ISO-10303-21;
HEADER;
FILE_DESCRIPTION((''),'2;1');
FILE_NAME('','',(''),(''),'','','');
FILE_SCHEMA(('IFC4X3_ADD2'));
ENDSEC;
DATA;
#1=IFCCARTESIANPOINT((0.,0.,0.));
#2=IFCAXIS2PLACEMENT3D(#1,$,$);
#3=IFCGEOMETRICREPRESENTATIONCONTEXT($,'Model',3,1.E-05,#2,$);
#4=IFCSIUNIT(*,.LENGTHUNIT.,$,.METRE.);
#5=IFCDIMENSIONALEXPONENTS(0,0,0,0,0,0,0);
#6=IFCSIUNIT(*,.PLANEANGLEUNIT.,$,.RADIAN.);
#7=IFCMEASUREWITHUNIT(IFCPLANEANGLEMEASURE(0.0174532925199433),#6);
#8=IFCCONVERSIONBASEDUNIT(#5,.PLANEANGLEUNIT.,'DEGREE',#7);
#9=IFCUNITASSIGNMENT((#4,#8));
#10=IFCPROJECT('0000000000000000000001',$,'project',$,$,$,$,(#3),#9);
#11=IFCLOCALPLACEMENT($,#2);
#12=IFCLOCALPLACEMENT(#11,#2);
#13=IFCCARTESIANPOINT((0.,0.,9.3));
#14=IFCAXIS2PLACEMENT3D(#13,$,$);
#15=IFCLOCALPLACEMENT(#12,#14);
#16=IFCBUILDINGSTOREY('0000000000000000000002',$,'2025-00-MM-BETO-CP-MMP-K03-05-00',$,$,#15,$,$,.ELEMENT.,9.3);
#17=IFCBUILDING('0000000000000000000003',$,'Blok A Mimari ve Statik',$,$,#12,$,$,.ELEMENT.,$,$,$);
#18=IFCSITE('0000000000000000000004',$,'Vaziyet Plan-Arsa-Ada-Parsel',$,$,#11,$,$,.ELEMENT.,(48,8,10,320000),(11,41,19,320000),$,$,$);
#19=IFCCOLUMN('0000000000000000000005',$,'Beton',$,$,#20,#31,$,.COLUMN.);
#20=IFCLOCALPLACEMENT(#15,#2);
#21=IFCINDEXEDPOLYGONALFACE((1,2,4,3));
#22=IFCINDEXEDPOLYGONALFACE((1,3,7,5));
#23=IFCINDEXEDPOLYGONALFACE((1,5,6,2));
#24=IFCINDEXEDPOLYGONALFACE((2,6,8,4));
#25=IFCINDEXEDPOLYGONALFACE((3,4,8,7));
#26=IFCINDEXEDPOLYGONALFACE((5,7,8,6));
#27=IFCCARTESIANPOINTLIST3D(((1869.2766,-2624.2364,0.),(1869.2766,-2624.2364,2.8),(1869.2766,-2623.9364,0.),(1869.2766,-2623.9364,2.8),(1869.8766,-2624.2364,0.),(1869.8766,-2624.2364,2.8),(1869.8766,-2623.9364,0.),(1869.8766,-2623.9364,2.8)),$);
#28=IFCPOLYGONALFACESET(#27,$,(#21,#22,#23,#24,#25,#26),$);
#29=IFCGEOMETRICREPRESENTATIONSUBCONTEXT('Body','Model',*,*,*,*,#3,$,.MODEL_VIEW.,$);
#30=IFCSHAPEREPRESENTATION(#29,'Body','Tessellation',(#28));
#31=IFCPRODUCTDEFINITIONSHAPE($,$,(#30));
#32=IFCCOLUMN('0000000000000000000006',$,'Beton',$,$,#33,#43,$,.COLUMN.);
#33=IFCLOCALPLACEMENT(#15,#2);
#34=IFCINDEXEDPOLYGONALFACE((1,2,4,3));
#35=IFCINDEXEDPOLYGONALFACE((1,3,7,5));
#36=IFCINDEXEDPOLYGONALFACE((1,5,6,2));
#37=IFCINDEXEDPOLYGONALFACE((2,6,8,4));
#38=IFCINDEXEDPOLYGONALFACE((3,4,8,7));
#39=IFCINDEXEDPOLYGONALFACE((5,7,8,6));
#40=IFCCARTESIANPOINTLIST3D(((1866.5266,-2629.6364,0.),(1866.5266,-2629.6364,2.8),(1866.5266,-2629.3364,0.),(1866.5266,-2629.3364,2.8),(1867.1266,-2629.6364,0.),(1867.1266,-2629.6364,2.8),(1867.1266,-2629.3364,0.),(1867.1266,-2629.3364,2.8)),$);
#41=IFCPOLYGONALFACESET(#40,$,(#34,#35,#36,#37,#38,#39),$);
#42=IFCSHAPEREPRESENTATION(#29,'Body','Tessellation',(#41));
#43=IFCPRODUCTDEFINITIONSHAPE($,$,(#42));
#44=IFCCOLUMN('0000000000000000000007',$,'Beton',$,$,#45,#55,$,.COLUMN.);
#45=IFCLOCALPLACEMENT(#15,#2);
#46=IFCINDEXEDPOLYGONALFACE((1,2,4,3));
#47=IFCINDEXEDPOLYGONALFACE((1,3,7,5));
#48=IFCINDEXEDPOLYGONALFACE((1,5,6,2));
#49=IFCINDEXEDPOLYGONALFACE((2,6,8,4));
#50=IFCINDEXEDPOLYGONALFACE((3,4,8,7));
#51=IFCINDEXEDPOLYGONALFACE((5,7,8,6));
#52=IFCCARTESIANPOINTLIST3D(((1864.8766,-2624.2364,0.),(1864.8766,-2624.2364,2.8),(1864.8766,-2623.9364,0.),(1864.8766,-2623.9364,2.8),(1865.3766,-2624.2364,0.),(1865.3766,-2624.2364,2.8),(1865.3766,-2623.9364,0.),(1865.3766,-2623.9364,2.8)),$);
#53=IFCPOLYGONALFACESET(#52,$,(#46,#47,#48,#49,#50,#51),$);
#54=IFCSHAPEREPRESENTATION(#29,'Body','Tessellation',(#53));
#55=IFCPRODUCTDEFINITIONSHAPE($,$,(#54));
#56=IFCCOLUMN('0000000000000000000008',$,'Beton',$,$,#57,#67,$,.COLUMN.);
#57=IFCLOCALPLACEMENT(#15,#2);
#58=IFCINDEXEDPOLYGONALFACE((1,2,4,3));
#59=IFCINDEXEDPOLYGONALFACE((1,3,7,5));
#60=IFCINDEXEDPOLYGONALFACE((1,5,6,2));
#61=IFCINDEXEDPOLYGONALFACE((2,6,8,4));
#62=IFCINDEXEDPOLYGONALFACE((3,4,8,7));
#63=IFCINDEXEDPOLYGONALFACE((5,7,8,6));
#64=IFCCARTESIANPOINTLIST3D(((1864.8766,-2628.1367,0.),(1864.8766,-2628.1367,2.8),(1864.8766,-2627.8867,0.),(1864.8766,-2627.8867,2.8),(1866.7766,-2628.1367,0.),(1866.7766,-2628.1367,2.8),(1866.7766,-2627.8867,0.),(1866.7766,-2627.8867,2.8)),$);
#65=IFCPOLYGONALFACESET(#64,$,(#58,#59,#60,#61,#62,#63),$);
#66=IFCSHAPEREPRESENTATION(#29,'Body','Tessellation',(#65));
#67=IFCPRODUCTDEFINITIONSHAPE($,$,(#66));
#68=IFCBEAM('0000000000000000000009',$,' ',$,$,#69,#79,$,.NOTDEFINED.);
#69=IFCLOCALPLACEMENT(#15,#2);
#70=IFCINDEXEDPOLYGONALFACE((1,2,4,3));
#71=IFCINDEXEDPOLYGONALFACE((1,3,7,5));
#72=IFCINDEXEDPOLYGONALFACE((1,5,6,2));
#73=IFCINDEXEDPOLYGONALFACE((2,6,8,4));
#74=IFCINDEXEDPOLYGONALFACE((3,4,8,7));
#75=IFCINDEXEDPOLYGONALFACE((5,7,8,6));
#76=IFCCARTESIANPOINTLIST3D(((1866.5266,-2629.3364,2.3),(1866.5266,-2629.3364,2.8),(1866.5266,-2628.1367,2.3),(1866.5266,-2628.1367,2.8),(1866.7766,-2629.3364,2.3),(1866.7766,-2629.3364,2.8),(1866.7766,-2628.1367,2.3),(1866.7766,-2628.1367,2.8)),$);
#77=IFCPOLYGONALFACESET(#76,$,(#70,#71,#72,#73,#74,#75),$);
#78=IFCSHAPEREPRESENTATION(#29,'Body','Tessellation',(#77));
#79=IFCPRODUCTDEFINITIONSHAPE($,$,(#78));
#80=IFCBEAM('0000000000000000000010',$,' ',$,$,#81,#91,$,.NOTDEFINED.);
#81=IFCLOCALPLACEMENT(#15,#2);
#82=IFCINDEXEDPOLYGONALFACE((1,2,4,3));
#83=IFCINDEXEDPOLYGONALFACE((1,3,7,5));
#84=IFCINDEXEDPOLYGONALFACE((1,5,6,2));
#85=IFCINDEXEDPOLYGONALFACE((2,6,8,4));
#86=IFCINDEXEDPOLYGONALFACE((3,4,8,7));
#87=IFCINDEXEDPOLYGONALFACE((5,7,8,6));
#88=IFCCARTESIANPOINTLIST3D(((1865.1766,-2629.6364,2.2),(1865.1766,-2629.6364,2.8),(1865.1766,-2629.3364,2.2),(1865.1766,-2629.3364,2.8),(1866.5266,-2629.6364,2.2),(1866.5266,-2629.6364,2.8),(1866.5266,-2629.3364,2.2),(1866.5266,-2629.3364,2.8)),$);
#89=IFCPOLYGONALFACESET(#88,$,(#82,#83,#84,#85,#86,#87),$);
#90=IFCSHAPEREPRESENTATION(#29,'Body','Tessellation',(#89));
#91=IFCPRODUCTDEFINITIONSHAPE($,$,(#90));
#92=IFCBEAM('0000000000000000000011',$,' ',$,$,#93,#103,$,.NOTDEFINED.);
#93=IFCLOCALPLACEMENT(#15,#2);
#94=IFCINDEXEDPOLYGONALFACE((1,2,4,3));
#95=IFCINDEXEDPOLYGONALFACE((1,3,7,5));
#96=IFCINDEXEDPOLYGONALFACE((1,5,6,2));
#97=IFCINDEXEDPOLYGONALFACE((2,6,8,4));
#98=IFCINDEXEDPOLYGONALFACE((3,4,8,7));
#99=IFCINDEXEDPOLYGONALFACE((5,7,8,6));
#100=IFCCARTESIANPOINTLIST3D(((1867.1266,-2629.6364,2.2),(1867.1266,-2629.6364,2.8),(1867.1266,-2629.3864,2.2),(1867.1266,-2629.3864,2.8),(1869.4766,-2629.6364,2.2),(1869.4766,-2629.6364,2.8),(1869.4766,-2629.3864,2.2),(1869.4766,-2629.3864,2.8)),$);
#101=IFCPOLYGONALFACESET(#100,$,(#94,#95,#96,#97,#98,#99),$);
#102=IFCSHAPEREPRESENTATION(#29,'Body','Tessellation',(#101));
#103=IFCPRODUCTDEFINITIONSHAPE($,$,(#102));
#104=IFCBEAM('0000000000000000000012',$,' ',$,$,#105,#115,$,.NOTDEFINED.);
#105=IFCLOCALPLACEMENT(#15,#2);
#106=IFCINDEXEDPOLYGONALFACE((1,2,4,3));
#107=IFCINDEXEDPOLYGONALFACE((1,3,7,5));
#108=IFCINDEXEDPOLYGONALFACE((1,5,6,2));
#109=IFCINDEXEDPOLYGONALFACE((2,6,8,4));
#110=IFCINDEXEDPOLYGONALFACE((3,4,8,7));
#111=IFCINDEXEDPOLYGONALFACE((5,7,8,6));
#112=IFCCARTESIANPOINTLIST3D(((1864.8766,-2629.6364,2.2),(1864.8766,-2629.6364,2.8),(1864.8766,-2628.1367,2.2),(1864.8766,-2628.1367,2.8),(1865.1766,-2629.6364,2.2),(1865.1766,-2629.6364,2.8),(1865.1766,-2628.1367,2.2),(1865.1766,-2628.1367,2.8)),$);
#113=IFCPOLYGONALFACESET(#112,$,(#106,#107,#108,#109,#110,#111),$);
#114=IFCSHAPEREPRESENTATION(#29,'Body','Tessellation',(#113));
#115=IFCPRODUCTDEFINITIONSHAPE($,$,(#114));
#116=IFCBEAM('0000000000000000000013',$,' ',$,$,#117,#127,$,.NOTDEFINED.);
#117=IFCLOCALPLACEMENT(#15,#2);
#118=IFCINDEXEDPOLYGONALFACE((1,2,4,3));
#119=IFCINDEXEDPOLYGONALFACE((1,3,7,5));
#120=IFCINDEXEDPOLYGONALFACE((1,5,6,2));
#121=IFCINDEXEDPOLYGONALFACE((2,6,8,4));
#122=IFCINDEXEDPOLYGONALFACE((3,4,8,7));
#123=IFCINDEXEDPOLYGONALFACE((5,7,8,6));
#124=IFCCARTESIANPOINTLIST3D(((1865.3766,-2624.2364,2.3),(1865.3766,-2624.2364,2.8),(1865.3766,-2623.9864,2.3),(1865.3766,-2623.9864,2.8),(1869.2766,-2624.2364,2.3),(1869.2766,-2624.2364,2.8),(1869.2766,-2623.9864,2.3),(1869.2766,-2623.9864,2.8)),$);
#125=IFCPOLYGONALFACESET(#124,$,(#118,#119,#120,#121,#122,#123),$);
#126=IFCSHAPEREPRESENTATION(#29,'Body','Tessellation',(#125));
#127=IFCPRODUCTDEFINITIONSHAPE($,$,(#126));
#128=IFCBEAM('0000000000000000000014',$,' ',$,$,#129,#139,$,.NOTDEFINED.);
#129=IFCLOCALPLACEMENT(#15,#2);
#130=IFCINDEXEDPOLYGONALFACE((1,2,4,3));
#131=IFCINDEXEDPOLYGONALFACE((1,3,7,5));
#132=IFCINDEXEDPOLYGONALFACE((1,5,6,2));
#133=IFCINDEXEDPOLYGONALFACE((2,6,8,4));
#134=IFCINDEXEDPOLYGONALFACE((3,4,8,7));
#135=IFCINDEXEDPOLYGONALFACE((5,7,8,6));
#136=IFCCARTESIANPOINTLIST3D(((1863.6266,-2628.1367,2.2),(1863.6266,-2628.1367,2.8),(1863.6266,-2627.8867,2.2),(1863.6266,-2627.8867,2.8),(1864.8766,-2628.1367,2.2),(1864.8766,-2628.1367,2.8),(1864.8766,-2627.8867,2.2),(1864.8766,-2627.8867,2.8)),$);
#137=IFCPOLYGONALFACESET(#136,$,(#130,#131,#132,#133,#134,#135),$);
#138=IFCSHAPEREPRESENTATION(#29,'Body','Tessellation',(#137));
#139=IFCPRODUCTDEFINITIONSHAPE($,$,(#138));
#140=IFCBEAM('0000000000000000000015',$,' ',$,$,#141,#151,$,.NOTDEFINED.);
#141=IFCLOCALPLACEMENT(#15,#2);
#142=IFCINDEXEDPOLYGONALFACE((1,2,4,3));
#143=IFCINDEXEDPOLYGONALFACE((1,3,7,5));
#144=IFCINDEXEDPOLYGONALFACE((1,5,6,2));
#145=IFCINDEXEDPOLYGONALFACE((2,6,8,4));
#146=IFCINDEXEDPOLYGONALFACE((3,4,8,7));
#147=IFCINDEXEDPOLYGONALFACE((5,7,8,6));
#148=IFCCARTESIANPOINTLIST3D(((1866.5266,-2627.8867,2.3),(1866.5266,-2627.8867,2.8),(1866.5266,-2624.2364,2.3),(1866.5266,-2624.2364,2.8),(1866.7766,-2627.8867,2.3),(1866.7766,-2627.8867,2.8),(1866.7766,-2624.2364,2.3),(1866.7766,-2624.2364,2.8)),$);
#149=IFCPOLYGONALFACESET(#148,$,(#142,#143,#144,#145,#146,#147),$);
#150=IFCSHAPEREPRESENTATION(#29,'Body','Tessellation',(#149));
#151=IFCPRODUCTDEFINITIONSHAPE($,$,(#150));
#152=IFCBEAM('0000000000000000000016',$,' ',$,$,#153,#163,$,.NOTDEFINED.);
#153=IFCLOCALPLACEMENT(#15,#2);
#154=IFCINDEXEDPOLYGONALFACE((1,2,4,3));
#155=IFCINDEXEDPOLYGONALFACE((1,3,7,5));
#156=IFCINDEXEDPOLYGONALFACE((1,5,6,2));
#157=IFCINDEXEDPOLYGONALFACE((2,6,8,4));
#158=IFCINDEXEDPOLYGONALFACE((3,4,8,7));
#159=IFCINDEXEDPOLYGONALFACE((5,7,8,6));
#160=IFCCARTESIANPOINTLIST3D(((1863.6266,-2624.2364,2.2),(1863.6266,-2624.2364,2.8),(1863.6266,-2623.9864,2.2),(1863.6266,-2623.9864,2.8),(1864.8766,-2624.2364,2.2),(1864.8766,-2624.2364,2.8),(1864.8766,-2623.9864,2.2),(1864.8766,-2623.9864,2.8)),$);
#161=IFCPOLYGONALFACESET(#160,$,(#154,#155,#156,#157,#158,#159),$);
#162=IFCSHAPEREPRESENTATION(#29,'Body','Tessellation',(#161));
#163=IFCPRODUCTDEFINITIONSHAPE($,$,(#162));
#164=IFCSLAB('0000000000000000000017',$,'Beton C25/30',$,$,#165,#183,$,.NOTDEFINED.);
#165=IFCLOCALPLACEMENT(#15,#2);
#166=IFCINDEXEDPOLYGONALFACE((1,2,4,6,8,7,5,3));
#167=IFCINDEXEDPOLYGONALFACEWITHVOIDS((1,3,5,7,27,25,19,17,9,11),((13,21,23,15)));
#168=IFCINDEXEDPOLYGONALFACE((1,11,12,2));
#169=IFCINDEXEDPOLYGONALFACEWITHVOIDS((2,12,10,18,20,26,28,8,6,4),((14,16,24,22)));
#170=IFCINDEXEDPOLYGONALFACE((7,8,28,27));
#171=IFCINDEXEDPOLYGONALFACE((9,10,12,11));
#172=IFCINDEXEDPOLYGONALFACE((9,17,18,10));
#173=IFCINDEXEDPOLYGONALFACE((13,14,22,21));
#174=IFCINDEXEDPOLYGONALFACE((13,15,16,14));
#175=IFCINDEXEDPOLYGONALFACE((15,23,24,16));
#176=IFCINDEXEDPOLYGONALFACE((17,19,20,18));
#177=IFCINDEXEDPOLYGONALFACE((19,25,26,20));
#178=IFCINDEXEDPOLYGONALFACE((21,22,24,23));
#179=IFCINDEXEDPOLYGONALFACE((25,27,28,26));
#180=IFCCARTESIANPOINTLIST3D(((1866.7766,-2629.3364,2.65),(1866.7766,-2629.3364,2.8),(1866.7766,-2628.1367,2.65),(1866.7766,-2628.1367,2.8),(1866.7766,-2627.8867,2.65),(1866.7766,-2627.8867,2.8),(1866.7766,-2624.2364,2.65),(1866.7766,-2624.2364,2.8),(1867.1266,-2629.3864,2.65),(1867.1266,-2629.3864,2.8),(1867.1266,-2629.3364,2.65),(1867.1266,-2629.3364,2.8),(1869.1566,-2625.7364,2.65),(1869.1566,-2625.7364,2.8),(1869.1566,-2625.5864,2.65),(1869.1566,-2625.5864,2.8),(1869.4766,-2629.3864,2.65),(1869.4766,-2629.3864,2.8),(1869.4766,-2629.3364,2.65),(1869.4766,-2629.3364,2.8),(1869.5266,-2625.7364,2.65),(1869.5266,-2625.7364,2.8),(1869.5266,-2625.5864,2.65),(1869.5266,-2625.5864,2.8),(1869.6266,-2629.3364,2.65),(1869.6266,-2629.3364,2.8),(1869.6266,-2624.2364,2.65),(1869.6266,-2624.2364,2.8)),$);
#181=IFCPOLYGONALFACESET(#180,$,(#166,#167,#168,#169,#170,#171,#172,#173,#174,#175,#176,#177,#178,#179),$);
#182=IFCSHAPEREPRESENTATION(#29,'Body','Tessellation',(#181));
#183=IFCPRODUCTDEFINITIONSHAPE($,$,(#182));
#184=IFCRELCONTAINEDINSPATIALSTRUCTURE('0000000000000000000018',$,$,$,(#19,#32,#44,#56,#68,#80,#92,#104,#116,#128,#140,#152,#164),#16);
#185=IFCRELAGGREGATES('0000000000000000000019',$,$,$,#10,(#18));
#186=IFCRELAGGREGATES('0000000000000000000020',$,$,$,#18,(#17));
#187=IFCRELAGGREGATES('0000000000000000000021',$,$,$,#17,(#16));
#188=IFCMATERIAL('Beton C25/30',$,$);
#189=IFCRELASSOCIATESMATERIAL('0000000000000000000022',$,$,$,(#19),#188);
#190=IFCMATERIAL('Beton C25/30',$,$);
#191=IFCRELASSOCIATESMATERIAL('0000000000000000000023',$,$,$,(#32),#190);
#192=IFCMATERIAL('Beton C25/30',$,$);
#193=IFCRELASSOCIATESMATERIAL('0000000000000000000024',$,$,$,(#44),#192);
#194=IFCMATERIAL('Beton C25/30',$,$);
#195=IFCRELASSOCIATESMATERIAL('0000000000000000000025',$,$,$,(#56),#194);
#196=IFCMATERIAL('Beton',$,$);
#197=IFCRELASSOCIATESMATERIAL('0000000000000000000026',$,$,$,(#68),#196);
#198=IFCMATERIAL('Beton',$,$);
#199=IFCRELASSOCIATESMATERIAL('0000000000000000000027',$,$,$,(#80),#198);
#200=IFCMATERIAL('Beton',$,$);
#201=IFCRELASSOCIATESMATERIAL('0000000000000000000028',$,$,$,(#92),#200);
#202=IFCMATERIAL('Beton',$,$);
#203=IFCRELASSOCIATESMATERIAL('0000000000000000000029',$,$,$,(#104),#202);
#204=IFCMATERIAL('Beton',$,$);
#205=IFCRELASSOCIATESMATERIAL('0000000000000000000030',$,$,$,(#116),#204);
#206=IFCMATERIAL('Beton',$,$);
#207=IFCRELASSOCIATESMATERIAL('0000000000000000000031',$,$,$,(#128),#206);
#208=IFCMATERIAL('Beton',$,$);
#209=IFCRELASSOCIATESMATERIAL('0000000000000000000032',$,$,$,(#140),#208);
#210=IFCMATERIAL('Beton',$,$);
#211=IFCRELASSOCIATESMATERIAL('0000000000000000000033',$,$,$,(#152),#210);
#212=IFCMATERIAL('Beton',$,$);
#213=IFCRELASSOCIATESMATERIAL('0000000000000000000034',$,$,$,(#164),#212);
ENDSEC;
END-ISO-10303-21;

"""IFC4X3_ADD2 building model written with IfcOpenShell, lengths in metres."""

from ifc_helpers import new_model, entity, si_unit, converted_unit, frame, frame_2d, origin, origin_with_axes, place, context, subcontext, project, spatial, polyline, rectangle, outline, extrude, material, element, save


model = new_model("IFC4X3_ADD2")

# Units and contexts
model_context = context("Model", 3, precision=1e-05, world=origin())
body_context = subcontext(model_context, "Body", "Model", "MODEL_VIEW")
ifc_project = project(units=[si_unit("LENGTHUNIT", "METRE"), converted_unit("PLANEANGLEUNIT", "DEGREE", entity("IfcPlaneAngleMeasure", 0.0174532925199433), si_unit("PLANEANGLEUNIT", "RADIAN"), dimensions=[0, 0, 0, 0, 0, 0, 0])], contexts=[model_context])

# Site, building, storey
site_placement = place(None, origin())
site = spatial("IfcSite", under=ifc_project, at=site_placement, Name="Vaziyet Plan-Arsa-Ada-Parsel", CompositionType="ELEMENT", RefLatitude=(48, 8, 10, 320000), RefLongitude=(11, 41, 19, 320000))
building_placement = place(site_placement, origin())
building = spatial("IfcBuilding", under=site, at=building_placement, Name="Blok A Mimari ve Statik", CompositionType="ELEMENT")
storey_placement = place(building_placement, frame((0.0, 0.0, 9.3)))
storey = spatial("IfcBuildingStorey", under=building, at=storey_placement, Name="2025-00-MM-BETO-CP-MMP-K03-05-00", CompositionType="ELEMENT", Elevation=9.3)

# Columns
ifc_material_1 = material(Name="Beton C25/30")
column_1_placement = place(storey_placement, frame((1869.2766, -2624.2364, 0.0)))
element("IfcColumn", 1, at=column_1_placement, inside=storey, material=ifc_material_1, Name="Beton", PredefinedType="COLUMN", context=body_context, shape_type="SweptSolid", body=[
    extrude(outline(polyline([(0.0, 0.0), (0.6, 0.0), (0.6, 0.3), (0.0, 0.3), (0.0, 0.0)])), origin_with_axes(), (0.0, 0.0, 1.0), 2.8),
])
ifc_material_2 = material(Name="Beton C25/30")
column_2_placement = place(storey_placement, frame((1866.5266, -2629.6364, 0.0)))
element("IfcColumn", 2, at=column_2_placement, inside=storey, material=ifc_material_2, Name="Beton", PredefinedType="COLUMN", context=body_context, shape_type="SweptSolid", body=[
    extrude(outline(polyline([(0.0, 0.3), (0.0, 0.0), (0.6, 0.0), (0.6, 0.3), (0.0, 0.3)])), origin_with_axes(), (0.0, 0.0, 1.0), 2.8),
])
ifc_material_3 = material(Name="Beton C25/30")
column_3_placement = place(storey_placement, frame((1864.8766, -2624.2364, 0.0)))
element("IfcColumn", 3, at=column_3_placement, inside=storey, material=ifc_material_3, Name="Beton", PredefinedType="COLUMN", context=body_context, shape_type="SweptSolid", body=[
    extrude(outline(polyline([(0.0, 0.0), (0.5, 0.0), (0.5, 0.3), (0.0, 0.3), (0.0, 0.0)])), origin_with_axes(), (0.0, 0.0, 1.0), 2.8),
])
ifc_material_4 = material(Name="Beton C25/30")
column_4_placement = place(storey_placement, frame((1864.8766, -2628.1367, 0.0)))
element("IfcColumn", 4, at=column_4_placement, inside=storey, material=ifc_material_4, Name="Beton", PredefinedType="COLUMN", context=body_context, shape_type="SweptSolid", body=[
    extrude(outline(polyline([(1.9, 0.25), (0.0, 0.25), (0.0, 0.0), (1.9, 0.0), (1.9, 0.25)])), origin_with_axes(), (0.0, 0.0, 1.0), 2.8),
])

# Beams
ifc_material_5 = material(Name="Beton")
beam_1_placement = place(storey_placement, frame((1866.5266, -2628.1367, 2.3), z_axis=(0.0, 0.0, 1.0), x_axis=(0.0, -1.0, 0.0)))
element("IfcBeam", 5, at=beam_1_placement, inside=storey, material=ifc_material_5, Name=" ", PredefinedType="NOTDEFINED", context=body_context, shape_type="SweptSolid", body=[
    extrude(rectangle(XDim=0.25, YDim=0.5, at=frame_2d((0.125, 0.25), x_axis=(1.0, 0.0))), frame((0.0, 0.0, 0.0), z_axis=(1.0, 0.0, 0.0), x_axis=(0.0, 1.0, 0.0)), (0.0, 0.0, 1.0), 1.1997),
])
ifc_material_6 = material(Name="Beton")
beam_2_placement = place(storey_placement, frame((1865.1766, -2629.6364, 2.2), z_axis=(0.0, 0.0, 1.0), x_axis=(1.0, 0.0, 0.0)))
element("IfcBeam", 6, at=beam_2_placement, inside=storey, material=ifc_material_6, Name=" ", PredefinedType="NOTDEFINED", context=body_context, shape_type="SweptSolid", body=[
    extrude(rectangle(XDim=0.3, YDim=0.6, at=frame_2d((0.15, 0.3), x_axis=(1.0, 0.0))), frame((0.0, 0.0, 0.0), z_axis=(1.0, 0.0, 0.0), x_axis=(0.0, 1.0, 0.0)), (0.0, 0.0, 1.0), 1.35),
])
ifc_material_7 = material(Name="Beton")
beam_3_placement = place(storey_placement, frame((1867.1266, -2629.6364, 2.2)))
element("IfcBeam", 7, at=beam_3_placement, inside=storey, material=ifc_material_7, Name=" ", PredefinedType="NOTDEFINED", context=body_context, shape_type="SweptSolid", body=[
    extrude(rectangle(XDim=0.25, YDim=0.6, at=frame_2d((0.125, 0.3), x_axis=(1.0, 0.0))), frame((0.0, 0.0, 0.0), z_axis=(1.0, 0.0, 0.0), x_axis=(0.0, 1.0, 0.0)), (0.0, 0.0, 1.0), 2.35),
])
ifc_material_8 = material(Name="Beton")
beam_4_placement = place(storey_placement, frame((1864.8766, -2628.1367, 2.2), z_axis=(0.0, 0.0, 1.0), x_axis=(0.0, -1.0, 0.0)))
element("IfcBeam", 8, at=beam_4_placement, inside=storey, material=ifc_material_8, Name=" ", PredefinedType="NOTDEFINED", context=body_context, shape_type="SweptSolid", body=[
    extrude(rectangle(XDim=0.3, YDim=0.6, at=frame_2d((0.15, 0.3), x_axis=(1.0, 0.0))), frame((0.0, 0.0, 0.0), z_axis=(1.0, 0.0, 0.0), x_axis=(0.0, 1.0, 0.0)), (0.0, 0.0, 1.0), 1.4997),
])
ifc_material_9 = material(Name="Beton")
beam_5_placement = place(storey_placement, frame((1865.3766, -2624.2364, 2.3), z_axis=(0.0, 0.0, 1.0), x_axis=(1.0, 0.0, 0.0)))
element("IfcBeam", 9, at=beam_5_placement, inside=storey, material=ifc_material_9, Name=" ", PredefinedType="NOTDEFINED", context=body_context, shape_type="SweptSolid", body=[
    extrude(rectangle(XDim=0.25, YDim=0.5, at=frame_2d((0.125, 0.25), x_axis=(1.0, 0.0))), frame((0.0, 0.0, 0.0), z_axis=(1.0, 0.0, 0.0), x_axis=(0.0, 1.0, 0.0)), (0.0, 0.0, 1.0), 3.9),
])
ifc_material_10 = material(Name="Beton")
beam_6_placement = place(storey_placement, frame((1863.6266, -2628.1367, 2.2), z_axis=(0.0, 0.0, 1.0), x_axis=(1.0, 0.000001, 0.0)))
element("IfcBeam", 10, at=beam_6_placement, inside=storey, material=ifc_material_10, Name=" ", PredefinedType="NOTDEFINED", context=body_context, shape_type="SweptSolid", body=[
    extrude(rectangle(XDim=0.25, YDim=0.6, at=frame_2d((0.125, 0.3), x_axis=(1.0, 0.0))), frame((0.0, 0.0, 0.0), z_axis=(1.0, 0.0, 0.0), x_axis=(0.0, 1.0, 0.0)), (0.0, 0.0, 1.0), 1.25),
])
ifc_material_11 = material(Name="Beton")
beam_7_placement = place(storey_placement, frame((1866.7766, -2627.8867, 2.3), z_axis=(0.0, 0.0, 1.0), x_axis=(0.0, 1.0, 0.0)))
element("IfcBeam", 11, at=beam_7_placement, inside=storey, material=ifc_material_11, Name=" ", PredefinedType="NOTDEFINED", context=body_context, shape_type="SweptSolid", body=[
    extrude(rectangle(XDim=0.25, YDim=0.5, at=frame_2d((0.125, 0.25), x_axis=(1.0, 0.0))), frame((0.0, 0.0, 0.0), z_axis=(1.0, 0.0, 0.0), x_axis=(0.0, 1.0, 0.0)), (0.0, 0.0, 1.0), 3.6503),
])
ifc_material_12 = material(Name="Beton")
beam_8_placement = place(storey_placement, frame((1863.6266, -2624.2364, 2.2), z_axis=(0.0, 0.0, 1.0), x_axis=(1.0, 0.000002, 0.0)))
element("IfcBeam", 12, at=beam_8_placement, inside=storey, material=ifc_material_12, Name=" ", PredefinedType="NOTDEFINED", context=body_context, shape_type="SweptSolid", body=[
    extrude(rectangle(XDim=0.25, YDim=0.6, at=frame_2d((0.125, 0.3), x_axis=(1.0, 0.0))), frame((0.0, 0.0, 0.0), z_axis=(1.0, 0.0, 0.0), x_axis=(0.0, 1.0, 0.0)), (0.0, 0.0, 1.0), 1.25),
])

# Slab
ifc_material_13 = material(Name="Beton")
slab_1_placement = place(storey_placement, frame((1866.7766, -2629.3864, 2.65)))
element("IfcSlab", 13, at=slab_1_placement, inside=storey, material=ifc_material_13, Name="Beton C25/30", PredefinedType="NOTDEFINED", context=body_context, shape_type="SweptSolid", body=[
    extrude(outline(polyline([(0.0, 5.15), (0.0, 1.4997), (0.0, 1.2497), (0.0, 0.05), (0.35, 0.05), (0.35, 0.0), (2.7, 0.0), (2.7, 0.05), (2.85, 0.05), (2.85, 5.15), (0.0, 5.15)]), holes=[polyline([(2.38, 3.8), (2.75, 3.8), (2.75, 3.65), (2.38, 3.65), (2.38, 3.8)])]), origin_with_axes(), (0.0, 0.0, 1.0), 0.15),
])

save(model, "model.ifc")
